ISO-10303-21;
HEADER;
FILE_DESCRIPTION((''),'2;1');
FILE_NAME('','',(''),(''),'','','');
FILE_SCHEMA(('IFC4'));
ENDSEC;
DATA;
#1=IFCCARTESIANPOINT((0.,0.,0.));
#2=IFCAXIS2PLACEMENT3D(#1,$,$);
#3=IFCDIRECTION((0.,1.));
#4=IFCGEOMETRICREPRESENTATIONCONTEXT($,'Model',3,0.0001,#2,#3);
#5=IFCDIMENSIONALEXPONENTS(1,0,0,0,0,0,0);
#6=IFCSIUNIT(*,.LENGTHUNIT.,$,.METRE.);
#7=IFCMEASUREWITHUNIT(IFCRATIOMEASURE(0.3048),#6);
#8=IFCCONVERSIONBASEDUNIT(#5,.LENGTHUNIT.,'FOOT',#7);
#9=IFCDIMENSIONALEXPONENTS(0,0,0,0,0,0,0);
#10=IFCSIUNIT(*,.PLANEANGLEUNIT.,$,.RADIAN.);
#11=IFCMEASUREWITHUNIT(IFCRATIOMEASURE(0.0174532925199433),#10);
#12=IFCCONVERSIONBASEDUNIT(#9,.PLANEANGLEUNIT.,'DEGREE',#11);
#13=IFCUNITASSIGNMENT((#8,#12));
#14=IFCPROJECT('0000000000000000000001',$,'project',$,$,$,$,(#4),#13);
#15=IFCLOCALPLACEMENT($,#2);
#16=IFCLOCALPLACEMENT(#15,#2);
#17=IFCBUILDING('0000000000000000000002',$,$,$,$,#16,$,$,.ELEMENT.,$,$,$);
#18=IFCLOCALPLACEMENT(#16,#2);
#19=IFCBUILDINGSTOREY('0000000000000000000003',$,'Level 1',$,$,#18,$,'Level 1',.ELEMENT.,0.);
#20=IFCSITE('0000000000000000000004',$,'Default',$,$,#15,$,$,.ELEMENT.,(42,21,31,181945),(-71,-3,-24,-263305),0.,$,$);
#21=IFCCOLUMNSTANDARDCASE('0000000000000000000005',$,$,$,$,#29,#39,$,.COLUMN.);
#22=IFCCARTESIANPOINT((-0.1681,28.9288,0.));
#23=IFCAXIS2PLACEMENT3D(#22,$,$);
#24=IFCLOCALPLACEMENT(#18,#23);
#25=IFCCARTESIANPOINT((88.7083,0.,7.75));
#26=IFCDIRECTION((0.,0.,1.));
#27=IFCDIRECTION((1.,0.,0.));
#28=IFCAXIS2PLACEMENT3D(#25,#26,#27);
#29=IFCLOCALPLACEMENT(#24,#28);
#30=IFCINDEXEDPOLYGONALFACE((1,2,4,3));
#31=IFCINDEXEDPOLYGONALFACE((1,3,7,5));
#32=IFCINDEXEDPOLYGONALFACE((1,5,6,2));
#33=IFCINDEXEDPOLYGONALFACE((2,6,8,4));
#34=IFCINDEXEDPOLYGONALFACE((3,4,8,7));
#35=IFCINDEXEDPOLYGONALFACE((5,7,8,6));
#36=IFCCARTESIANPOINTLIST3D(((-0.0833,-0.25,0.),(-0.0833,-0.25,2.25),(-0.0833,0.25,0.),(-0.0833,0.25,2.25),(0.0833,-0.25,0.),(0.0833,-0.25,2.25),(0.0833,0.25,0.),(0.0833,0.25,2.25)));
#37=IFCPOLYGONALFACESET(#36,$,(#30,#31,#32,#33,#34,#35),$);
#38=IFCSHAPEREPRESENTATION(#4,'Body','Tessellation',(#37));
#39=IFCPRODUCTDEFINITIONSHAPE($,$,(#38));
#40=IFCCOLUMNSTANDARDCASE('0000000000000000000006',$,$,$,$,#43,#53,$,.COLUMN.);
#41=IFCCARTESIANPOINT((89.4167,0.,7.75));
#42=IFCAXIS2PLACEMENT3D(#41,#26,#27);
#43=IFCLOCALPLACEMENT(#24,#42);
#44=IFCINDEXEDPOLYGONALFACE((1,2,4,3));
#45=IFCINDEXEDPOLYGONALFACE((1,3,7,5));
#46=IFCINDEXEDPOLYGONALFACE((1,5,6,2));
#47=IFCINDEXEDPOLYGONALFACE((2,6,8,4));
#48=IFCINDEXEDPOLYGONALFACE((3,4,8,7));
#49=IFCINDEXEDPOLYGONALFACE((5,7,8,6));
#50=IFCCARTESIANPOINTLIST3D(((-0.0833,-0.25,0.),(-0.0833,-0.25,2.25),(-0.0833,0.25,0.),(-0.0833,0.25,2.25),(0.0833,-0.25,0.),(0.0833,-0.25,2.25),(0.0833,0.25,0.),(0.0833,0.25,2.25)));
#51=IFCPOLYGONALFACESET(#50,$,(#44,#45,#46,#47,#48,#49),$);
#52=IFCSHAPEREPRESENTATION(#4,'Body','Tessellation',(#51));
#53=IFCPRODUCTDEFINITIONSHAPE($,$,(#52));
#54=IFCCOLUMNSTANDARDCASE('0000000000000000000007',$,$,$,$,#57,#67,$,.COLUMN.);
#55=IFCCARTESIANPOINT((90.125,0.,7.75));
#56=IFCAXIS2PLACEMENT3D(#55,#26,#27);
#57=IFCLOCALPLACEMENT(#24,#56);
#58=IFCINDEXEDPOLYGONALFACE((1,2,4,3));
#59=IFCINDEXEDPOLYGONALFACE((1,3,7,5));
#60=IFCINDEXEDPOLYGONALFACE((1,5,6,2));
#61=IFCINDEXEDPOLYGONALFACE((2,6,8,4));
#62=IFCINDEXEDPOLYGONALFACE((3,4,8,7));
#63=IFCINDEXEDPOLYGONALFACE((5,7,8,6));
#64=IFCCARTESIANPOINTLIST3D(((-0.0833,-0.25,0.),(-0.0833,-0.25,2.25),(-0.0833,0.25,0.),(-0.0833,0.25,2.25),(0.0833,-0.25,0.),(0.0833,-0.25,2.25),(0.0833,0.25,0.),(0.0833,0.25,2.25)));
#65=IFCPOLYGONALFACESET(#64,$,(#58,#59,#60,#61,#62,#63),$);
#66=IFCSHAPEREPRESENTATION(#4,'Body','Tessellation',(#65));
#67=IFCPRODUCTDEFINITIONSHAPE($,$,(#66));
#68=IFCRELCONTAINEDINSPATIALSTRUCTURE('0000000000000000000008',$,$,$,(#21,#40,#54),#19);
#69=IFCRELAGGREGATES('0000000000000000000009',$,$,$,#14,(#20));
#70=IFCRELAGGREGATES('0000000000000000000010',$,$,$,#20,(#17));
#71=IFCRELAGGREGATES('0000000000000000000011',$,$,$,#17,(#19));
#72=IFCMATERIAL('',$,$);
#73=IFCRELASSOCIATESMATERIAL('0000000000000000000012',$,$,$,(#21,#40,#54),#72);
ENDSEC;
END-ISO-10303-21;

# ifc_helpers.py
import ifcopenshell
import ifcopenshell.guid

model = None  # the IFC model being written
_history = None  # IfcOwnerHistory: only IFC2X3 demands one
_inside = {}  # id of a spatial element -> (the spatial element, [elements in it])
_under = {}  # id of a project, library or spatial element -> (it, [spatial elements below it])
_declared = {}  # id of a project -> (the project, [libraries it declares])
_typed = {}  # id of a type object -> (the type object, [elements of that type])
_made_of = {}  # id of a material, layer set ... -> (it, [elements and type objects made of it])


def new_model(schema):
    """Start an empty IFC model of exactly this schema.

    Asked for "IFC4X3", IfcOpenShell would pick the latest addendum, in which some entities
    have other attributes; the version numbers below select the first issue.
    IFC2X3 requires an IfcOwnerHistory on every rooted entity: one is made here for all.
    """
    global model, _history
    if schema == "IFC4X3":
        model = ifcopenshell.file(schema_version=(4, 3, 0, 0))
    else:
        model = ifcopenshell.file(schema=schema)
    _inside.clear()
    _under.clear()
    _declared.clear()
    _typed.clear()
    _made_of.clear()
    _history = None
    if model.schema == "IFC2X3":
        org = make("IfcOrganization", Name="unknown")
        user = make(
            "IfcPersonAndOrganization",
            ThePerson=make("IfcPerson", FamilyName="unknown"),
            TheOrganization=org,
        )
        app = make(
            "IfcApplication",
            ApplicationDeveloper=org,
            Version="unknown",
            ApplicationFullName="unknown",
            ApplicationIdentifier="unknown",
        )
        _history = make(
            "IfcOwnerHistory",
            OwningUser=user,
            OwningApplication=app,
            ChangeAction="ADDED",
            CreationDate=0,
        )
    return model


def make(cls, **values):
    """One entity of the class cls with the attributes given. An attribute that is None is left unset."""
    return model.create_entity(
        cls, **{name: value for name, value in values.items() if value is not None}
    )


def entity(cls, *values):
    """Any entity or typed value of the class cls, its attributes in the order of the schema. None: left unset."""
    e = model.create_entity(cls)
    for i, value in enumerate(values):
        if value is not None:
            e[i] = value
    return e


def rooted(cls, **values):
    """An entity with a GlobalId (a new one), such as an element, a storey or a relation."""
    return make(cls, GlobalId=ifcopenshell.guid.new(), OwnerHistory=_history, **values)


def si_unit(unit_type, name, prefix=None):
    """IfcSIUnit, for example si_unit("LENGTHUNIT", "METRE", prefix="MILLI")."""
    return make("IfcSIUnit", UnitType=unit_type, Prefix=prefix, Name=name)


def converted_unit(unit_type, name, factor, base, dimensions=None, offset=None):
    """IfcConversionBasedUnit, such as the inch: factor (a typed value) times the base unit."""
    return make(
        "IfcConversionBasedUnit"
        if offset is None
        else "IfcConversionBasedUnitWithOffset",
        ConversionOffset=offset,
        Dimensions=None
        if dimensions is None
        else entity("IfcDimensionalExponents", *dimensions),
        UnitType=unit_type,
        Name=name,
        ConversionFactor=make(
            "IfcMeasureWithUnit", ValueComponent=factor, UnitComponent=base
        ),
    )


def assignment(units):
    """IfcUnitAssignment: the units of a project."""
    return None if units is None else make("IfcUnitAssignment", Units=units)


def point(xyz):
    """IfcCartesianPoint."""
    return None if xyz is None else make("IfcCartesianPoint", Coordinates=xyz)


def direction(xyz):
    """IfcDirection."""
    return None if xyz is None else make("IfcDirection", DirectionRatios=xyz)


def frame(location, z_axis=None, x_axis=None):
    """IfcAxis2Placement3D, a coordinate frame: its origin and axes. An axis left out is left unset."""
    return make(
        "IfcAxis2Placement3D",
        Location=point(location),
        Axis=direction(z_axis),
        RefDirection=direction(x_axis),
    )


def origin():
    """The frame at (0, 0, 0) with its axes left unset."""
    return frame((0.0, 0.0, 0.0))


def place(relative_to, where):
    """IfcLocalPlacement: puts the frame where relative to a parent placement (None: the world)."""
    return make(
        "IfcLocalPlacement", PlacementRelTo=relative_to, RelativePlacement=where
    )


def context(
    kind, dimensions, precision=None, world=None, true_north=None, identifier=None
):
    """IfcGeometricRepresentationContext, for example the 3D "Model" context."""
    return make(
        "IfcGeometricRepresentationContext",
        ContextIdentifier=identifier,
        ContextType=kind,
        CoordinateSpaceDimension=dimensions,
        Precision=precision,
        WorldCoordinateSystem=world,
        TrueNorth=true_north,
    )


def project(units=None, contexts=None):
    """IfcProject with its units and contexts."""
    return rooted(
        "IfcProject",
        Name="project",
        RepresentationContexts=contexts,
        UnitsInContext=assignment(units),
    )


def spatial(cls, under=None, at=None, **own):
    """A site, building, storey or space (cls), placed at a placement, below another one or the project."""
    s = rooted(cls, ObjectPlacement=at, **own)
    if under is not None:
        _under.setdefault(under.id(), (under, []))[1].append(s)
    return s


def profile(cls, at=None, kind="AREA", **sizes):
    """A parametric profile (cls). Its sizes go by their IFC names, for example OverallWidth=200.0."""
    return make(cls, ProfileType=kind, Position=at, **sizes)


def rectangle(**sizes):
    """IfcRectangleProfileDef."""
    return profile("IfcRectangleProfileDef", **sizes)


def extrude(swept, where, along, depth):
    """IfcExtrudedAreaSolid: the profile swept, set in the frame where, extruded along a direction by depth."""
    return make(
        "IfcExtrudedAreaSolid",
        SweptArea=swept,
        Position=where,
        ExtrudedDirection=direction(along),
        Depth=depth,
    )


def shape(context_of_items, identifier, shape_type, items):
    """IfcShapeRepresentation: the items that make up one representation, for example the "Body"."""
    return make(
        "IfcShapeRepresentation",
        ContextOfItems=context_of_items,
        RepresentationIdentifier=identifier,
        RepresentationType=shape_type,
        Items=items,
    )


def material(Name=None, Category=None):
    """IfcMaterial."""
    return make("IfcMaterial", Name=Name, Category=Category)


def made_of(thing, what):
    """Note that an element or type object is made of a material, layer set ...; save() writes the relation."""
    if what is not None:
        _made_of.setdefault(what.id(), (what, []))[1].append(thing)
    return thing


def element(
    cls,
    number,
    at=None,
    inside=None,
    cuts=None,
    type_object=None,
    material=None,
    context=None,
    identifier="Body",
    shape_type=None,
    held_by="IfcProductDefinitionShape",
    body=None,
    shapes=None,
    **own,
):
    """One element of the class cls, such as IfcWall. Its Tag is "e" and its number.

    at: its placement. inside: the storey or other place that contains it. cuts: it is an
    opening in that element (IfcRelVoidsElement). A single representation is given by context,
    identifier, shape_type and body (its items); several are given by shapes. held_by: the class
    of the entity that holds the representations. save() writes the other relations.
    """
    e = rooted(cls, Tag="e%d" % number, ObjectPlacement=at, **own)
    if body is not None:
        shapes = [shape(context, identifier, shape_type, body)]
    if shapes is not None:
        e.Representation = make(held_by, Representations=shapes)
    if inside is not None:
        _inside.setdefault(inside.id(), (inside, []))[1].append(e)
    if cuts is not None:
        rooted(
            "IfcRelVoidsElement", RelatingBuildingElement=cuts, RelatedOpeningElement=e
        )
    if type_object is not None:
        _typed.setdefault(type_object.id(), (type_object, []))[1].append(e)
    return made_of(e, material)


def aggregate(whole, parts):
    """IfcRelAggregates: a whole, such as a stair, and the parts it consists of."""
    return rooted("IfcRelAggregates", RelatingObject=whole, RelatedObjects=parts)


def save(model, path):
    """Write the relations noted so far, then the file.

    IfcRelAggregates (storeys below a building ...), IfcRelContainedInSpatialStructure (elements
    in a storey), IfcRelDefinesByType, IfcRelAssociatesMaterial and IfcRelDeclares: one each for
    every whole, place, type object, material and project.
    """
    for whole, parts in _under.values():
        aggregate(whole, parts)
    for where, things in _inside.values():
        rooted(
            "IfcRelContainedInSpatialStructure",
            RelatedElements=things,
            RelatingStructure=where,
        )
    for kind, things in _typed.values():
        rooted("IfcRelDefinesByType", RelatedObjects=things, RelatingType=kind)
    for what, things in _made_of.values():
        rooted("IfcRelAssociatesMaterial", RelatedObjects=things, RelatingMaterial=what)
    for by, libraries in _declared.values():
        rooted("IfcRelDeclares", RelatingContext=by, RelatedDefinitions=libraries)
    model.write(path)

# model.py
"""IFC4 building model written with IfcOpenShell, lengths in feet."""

from ifc_helpers import new_model, entity, si_unit, converted_unit, direction, frame, origin, place, context, project, spatial, rectangle, extrude, material, element, save


model = new_model("IFC4")

# Units and contexts
model_context = context("Model", 3, precision=0.0001, world=origin(), true_north=direction((0.0, 1.0)))
ifc_project = project(units=[converted_unit("LENGTHUNIT", "FOOT", entity("IfcRatioMeasure", 0.3048), si_unit("LENGTHUNIT", "METRE"), dimensions=[1, 0, 0, 0, 0, 0, 0]), converted_unit("PLANEANGLEUNIT", "DEGREE", entity("IfcRatioMeasure", 0.0174532925199433), si_unit("PLANEANGLEUNIT", "RADIAN"), dimensions=[0, 0, 0, 0, 0, 0, 0])], contexts=[model_context])

# Site, building, storey
site_placement = place(None, origin())
site = spatial("IfcSite", under=ifc_project, at=site_placement, Name="Default", CompositionType="ELEMENT", RefLatitude=(42, 21, 31, 181945), RefLongitude=(-71, -3, -24, -263305), RefElevation=0.0)
building_placement = place(site_placement, origin())
building = spatial("IfcBuilding", under=site, at=building_placement, CompositionType="ELEMENT")
storey_placement = place(building_placement, origin())
storey = spatial("IfcBuildingStorey", under=building, at=storey_placement, Name="Level 1", LongName="Level 1", CompositionType="ELEMENT", Elevation=0.0)

# Columns
ifc_material_1 = material(Name="")
placement = place(storey_placement, frame((-0.1681, 28.9288, 0.0)))
for number, where, z_axis, x_axis in (
    (1, (88.7083, 0.0, 7.75), (0.0, 0.0, 1.0), (1.0, 0.0, 0.0)),
    (2, (89.4167, 0.0, 7.75), (0.0, 0.0, 1.0), (1.0, 0.0, 0.0)),
    (3, (90.125, 0.0, 7.75), (0.0, 0.0, 1.0), (1.0, 0.0, 0.0)),
):
    element("IfcColumnStandardCase", number, at=place(placement, frame(where, z_axis=z_axis, x_axis=x_axis)), inside=storey, material=ifc_material_1, PredefinedType="COLUMN", context=model_context, shape_type="SweptSolid", body=[
        extrude(rectangle(XDim=0.1667, YDim=0.5), origin(), (0.0, 0.0, 1.0), 2.25),
    ])

save(model, "model.ifc")
